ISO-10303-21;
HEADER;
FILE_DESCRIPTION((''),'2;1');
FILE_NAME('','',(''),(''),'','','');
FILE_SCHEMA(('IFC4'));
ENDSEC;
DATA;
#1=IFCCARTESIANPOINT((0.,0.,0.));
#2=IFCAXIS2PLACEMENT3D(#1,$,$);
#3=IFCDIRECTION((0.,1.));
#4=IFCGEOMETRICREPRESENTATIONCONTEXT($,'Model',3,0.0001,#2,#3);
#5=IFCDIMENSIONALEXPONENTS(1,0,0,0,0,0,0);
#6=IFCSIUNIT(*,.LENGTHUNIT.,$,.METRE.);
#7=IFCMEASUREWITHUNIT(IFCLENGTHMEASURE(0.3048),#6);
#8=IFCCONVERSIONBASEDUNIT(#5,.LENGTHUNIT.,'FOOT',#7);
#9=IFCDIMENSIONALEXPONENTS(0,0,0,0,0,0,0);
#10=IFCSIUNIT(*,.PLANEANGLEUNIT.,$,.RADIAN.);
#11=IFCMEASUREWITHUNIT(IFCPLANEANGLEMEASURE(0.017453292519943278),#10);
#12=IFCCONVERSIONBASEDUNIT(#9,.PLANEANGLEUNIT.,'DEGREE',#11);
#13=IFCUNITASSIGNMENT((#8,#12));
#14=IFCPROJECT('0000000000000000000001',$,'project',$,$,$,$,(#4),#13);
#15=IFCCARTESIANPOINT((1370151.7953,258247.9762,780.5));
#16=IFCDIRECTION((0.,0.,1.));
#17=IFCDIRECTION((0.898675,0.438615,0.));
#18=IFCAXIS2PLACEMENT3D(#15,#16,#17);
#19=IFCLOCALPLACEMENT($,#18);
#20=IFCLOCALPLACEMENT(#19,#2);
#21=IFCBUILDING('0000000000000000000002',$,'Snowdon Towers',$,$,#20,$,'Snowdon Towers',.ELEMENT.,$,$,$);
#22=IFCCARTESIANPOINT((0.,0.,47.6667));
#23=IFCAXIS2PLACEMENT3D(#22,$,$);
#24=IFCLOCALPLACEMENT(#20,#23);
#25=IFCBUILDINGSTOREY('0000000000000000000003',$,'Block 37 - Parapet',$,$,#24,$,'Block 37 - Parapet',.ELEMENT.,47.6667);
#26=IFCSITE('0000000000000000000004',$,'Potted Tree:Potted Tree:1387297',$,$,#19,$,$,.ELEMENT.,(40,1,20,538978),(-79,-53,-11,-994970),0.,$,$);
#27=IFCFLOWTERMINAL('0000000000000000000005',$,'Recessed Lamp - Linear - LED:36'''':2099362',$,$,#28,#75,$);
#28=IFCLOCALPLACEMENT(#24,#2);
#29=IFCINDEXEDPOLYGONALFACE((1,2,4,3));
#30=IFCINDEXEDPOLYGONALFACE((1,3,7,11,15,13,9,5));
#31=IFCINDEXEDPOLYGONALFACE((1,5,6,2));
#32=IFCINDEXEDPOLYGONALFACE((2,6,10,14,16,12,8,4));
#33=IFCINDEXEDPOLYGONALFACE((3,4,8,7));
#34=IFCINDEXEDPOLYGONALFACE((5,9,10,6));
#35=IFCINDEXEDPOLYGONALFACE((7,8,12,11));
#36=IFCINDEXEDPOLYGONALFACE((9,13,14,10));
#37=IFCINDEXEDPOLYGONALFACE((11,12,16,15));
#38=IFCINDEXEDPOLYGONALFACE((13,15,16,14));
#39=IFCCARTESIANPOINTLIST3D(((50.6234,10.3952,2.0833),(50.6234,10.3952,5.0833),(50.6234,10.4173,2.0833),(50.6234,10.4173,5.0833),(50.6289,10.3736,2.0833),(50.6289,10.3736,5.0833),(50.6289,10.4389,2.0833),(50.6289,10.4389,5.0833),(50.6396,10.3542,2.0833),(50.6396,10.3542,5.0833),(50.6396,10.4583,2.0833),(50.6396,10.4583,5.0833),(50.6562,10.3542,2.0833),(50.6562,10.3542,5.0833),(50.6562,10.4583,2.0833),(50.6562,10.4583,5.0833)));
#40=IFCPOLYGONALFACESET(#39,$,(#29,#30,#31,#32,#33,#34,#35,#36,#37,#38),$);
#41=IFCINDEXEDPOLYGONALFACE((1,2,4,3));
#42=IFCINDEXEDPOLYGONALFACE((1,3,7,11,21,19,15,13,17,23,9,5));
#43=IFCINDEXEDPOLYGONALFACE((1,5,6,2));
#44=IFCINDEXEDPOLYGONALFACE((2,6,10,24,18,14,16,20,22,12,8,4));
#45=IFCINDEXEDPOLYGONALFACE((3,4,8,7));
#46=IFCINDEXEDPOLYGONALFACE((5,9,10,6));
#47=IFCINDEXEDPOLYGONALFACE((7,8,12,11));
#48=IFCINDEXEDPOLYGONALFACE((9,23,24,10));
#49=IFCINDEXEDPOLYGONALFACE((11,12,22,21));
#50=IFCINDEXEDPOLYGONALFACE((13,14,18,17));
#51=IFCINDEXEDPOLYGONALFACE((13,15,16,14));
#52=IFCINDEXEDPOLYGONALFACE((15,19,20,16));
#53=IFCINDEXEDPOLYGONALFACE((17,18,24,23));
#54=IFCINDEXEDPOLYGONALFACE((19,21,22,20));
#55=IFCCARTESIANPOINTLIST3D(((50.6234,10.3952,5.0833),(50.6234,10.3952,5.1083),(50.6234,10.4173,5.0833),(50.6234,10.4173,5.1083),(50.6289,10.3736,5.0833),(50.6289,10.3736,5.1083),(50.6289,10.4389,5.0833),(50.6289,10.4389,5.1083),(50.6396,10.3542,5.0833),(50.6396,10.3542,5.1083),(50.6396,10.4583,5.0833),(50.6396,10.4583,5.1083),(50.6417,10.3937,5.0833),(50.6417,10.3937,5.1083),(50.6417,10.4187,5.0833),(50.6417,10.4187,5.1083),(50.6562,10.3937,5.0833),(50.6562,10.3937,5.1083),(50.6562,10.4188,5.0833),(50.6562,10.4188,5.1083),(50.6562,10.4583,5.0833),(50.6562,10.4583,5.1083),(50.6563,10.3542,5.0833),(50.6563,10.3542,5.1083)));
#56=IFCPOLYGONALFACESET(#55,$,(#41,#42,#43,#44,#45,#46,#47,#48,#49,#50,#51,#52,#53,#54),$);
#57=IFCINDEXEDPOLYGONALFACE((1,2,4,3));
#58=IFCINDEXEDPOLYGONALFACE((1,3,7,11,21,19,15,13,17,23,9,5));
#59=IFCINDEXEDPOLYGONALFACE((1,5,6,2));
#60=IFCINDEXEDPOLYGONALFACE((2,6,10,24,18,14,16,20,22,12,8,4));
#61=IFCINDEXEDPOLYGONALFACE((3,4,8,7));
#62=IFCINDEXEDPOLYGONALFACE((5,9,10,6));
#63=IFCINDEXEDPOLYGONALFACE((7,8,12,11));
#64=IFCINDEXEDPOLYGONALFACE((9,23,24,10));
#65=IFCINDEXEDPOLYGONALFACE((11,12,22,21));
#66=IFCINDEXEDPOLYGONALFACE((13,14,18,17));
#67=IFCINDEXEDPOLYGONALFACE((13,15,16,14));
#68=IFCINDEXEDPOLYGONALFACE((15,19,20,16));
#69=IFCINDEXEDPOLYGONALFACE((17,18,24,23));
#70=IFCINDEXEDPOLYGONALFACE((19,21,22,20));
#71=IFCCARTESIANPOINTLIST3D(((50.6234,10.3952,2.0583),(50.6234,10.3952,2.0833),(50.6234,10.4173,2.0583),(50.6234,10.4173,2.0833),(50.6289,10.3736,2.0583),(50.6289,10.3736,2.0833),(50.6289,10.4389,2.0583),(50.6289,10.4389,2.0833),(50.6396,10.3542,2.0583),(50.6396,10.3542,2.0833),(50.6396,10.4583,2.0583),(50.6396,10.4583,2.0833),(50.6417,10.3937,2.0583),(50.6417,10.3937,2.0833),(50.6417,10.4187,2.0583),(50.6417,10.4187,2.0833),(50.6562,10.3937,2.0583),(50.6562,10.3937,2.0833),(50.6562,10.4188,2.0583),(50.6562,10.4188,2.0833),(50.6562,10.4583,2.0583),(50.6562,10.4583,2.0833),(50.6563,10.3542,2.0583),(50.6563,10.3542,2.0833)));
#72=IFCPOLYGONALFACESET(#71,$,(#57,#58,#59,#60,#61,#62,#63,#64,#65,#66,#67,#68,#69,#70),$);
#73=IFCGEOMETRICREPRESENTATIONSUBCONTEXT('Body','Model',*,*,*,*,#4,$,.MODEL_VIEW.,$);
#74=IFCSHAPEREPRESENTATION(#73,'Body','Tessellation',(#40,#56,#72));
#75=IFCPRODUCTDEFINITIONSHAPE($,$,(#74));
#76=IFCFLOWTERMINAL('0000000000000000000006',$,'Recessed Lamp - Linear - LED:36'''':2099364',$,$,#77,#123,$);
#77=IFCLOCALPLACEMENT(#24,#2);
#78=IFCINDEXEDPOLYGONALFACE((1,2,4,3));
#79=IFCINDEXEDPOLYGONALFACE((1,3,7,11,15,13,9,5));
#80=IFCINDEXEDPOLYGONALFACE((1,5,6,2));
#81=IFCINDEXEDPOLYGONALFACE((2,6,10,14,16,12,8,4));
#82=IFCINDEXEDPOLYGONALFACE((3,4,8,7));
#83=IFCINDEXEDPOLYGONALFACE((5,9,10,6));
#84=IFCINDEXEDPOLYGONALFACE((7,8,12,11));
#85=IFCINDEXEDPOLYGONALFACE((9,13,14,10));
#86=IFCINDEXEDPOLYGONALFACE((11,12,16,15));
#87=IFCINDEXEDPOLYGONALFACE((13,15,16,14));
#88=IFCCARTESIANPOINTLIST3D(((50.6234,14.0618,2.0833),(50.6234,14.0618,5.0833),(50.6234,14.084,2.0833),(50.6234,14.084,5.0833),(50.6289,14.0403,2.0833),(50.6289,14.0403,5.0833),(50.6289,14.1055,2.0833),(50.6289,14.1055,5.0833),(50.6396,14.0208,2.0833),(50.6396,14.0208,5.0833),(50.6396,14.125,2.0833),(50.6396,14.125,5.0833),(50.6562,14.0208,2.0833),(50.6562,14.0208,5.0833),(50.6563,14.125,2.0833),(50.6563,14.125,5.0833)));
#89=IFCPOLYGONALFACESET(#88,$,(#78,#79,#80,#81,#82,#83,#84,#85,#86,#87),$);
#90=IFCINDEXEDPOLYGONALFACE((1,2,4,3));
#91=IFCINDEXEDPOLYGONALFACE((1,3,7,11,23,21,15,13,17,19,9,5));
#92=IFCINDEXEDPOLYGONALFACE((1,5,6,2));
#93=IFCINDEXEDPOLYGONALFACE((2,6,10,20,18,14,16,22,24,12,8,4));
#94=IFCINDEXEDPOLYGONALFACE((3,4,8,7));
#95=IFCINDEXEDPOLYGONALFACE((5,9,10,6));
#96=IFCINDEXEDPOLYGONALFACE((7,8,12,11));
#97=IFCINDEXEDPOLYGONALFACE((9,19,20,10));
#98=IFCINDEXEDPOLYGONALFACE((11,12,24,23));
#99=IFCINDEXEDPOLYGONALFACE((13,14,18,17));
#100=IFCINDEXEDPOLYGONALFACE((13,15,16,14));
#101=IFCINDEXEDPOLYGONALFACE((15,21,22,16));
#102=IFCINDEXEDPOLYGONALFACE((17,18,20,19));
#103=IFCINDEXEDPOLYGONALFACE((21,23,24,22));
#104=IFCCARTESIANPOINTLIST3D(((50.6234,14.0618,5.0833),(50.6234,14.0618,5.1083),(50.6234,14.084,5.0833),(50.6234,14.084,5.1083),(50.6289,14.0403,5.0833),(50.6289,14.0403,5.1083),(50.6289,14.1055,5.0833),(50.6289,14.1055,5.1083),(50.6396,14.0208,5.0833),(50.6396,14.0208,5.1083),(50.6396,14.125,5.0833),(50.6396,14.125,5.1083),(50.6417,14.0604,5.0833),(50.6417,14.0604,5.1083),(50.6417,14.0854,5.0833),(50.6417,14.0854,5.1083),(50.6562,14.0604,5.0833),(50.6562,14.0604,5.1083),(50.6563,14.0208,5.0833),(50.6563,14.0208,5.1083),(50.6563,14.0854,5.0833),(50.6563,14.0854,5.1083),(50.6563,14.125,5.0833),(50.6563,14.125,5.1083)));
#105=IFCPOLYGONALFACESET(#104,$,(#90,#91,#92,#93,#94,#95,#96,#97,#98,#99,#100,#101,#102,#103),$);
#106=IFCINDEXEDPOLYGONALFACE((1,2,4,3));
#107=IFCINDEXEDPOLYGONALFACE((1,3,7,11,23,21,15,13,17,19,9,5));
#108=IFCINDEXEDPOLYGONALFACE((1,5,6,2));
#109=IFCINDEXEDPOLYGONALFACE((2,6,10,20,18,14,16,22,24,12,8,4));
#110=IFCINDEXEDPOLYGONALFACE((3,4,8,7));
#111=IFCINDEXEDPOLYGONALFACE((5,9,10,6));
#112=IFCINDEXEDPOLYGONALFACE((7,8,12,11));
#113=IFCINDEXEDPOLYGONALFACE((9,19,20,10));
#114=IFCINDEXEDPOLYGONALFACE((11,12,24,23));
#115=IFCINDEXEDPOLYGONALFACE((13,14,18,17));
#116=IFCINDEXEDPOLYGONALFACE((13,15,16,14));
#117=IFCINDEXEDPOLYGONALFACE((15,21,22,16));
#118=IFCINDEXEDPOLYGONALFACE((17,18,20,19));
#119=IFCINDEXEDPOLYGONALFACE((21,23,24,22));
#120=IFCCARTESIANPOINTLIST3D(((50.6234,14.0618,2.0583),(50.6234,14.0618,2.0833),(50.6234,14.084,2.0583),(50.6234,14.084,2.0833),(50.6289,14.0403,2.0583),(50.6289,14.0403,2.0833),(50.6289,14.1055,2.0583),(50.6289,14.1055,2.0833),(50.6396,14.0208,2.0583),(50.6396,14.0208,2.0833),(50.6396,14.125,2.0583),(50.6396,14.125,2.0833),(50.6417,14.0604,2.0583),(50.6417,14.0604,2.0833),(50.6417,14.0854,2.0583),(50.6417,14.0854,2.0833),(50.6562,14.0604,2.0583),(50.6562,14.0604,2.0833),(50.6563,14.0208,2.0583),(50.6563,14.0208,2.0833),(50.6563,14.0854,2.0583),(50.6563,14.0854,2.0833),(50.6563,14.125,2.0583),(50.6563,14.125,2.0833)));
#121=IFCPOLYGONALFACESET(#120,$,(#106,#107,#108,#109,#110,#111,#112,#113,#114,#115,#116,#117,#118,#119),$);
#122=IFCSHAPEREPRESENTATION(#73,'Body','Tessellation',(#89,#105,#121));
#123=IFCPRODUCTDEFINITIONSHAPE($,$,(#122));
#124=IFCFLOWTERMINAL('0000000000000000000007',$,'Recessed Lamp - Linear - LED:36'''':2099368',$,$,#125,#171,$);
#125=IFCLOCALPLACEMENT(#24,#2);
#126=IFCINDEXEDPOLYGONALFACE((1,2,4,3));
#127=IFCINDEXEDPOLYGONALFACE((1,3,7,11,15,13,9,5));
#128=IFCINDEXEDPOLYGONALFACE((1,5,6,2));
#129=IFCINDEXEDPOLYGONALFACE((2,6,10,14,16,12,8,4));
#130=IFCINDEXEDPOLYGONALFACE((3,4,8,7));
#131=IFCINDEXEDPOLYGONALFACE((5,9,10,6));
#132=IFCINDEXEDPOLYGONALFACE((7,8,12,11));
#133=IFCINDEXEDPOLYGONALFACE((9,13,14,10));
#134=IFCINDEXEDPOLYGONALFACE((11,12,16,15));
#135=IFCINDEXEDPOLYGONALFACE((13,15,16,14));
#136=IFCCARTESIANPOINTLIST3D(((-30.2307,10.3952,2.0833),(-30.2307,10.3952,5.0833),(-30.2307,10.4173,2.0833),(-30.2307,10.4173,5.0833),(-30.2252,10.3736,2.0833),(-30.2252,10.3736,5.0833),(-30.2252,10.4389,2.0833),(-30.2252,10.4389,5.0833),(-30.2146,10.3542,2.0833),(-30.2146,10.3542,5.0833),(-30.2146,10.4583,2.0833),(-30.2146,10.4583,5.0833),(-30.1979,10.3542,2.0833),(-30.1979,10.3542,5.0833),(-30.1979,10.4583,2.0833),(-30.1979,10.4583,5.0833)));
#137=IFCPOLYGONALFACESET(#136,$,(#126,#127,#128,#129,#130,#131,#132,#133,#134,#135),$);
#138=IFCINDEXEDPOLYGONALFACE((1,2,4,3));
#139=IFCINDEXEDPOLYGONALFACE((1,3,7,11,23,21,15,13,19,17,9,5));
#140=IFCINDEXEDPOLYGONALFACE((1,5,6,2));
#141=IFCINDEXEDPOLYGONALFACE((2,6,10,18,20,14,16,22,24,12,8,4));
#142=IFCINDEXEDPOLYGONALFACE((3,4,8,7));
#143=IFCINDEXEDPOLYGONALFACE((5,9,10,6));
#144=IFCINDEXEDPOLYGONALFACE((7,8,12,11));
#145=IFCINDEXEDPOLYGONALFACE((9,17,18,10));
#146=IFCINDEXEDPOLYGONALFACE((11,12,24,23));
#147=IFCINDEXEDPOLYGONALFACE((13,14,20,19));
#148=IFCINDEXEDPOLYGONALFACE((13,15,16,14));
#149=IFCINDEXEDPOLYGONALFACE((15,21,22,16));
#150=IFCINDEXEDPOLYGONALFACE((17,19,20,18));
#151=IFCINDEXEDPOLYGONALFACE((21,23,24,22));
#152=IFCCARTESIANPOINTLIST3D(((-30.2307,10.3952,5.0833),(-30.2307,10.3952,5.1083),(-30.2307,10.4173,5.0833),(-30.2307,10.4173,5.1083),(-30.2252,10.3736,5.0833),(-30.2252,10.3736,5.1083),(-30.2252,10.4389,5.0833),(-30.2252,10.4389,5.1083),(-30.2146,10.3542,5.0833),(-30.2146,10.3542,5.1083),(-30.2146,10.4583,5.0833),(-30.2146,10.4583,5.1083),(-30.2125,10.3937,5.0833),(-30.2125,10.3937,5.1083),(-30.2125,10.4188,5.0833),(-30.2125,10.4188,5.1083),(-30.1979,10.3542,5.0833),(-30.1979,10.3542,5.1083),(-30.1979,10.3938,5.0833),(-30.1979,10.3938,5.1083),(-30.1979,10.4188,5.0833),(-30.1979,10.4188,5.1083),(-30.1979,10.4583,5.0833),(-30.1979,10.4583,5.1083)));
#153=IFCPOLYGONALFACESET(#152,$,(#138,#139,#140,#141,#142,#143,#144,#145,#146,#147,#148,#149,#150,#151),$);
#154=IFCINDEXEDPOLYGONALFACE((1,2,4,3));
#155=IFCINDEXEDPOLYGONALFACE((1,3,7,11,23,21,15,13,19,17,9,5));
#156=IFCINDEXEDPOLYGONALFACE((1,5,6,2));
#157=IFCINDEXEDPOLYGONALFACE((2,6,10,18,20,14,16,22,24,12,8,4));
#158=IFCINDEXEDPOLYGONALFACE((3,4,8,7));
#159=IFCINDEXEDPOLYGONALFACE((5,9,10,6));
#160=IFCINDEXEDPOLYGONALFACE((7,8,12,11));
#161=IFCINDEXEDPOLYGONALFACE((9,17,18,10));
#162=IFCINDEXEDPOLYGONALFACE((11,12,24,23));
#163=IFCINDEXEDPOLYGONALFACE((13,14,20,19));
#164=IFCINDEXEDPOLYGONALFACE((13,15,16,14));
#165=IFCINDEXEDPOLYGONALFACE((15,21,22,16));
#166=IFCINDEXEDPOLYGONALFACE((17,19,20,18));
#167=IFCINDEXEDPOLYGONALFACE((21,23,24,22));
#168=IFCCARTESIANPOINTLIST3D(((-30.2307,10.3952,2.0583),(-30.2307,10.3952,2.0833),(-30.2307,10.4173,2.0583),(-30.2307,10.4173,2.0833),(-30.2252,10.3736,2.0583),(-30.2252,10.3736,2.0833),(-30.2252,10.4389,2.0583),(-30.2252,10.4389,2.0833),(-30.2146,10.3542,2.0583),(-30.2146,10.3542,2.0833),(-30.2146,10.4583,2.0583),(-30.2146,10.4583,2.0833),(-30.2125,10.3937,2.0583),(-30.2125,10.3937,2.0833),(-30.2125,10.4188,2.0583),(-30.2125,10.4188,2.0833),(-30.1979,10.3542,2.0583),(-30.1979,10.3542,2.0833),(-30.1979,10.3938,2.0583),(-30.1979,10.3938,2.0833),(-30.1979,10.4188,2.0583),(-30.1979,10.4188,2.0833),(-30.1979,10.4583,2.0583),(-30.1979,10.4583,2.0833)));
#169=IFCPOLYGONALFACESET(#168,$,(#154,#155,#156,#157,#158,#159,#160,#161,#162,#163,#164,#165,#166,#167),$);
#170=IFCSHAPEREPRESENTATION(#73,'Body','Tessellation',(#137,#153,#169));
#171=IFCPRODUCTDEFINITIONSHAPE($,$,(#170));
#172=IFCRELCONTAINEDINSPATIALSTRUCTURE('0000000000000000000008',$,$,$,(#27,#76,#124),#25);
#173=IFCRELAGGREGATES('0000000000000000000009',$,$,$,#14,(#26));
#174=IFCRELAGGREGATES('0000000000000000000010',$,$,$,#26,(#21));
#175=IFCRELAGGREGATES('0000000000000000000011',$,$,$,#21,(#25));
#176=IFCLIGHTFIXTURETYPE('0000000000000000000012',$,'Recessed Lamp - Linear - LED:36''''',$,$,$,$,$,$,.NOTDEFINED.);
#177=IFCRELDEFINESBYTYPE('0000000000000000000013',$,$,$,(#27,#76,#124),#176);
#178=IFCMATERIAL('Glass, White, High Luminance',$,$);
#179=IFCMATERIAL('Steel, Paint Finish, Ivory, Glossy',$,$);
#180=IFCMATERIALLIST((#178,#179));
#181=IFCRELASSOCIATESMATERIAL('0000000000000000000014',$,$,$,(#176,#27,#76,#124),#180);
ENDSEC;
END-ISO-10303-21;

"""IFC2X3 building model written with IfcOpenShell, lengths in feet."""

from ifc_helpers import new_model, entity, si_unit, converted_unit, direction, frame, frame_2d, origin, place, context, subcontext, project, spatial, polyline, circle_curve, parameter, trimmed, segment, composite_curve, outline, extrude, source, transform, mapped, material, material_list, type_object, type_shapes, element, save


model = new_model("IFC2X3")

# Units and contexts
model_context = context("Model", 3, precision=0.0001, world=origin(), true_north=direction((0.0, 1.0)))
body_context = subcontext(model_context, "Body", "Model", "MODEL_VIEW")
ifc_project = project(units=[converted_unit("LENGTHUNIT", "FOOT", entity("IfcLengthMeasure", 0.3048), si_unit("LENGTHUNIT", "METRE"), dimensions=[1, 0, 0, 0, 0, 0, 0]), converted_unit("PLANEANGLEUNIT", "DEGREE", entity("IfcPlaneAngleMeasure", 0.017453292519943278), si_unit("PLANEANGLEUNIT", "RADIAN"), dimensions=[0, 0, 0, 0, 0, 0, 0])], contexts=[model_context])

# Site, building, storey
site_placement = place(None, frame((1370151.7953, 258247.9762, 780.5), z_axis=(0.0, 0.0, 1.0), x_axis=(0.898675, 0.438615, 0.0)))
site = spatial("IfcSite", under=ifc_project, at=site_placement, Name="Potted Tree:Potted Tree:1387297", CompositionType="ELEMENT", RefLatitude=(40, 1, 20, 538978), RefLongitude=(-79, -53, -11, -994970), RefElevation=0.0)
building_placement = place(site_placement, origin())
building = spatial("IfcBuilding", under=site, at=building_placement, Name="Snowdon Towers", LongName="Snowdon Towers", CompositionType="ELEMENT")
storey_placement = place(building_placement, frame((0.0, 0.0, 47.6667)))
storey = spatial("IfcBuildingStorey", under=building, at=storey_placement, Name="Block 37 - Parapet", LongName="Block 37 - Parapet", CompositionType="ELEMENT", Elevation=47.6667)

# Flow terminals
ifc_material_1 = material(Name="Glass, White, High Luminance")
ifc_material_2 = material(Name="Steel, Paint Finish, Ivory, Glossy")
ifc_material_list = material_list([ifc_material_1, ifc_material_2])
light_fixture_type = type_object("IfcLightFixtureType", Name="Recessed Lamp - Linear - LED:36''", PredefinedType="NOTDEFINED", material=ifc_material_list)
shared_shape = source(origin(), body_context, "Body", "SweptSolid", [
    extrude(outline(composite_curve([segment(trimmed(circle_curve(frame_2d((0.0, -0.0639), x_axis=(1.0, 0.0)), 0.089), [parameter(54.196986)], [parameter(125.803014)], True, "PARAMETER"), True, "CONTINUOUS"), segment(polyline([(-0.0521, 0.0083), (-0.0521, -0.0083)]), True, "CONTINUOUS"), segment(polyline([(-0.0521, -0.0083), (0.0521, -0.0083)]), True, "CONTINUOUS"), segment(polyline([(0.0521, -0.0083), (0.0521, 0.0083)]), True, "CONTINUOUS")], self_intersect=False)), frame((-1.5, 0.0, 0.0083), z_axis=(1.0, 0.0, 0.0), x_axis=(0.0, 1.0, 0.0)), (0.0, 0.0, 1.0), 3.0),
    extrude(outline(composite_curve([segment(trimmed(circle_curve(frame_2d((0.0, -0.0633), x_axis=(1.0, 0.0)), 0.089), [parameter(54.196986)], [parameter(125.803014)], True, "PARAMETER"), True, "CONTINUOUS"), segment(polyline([(-0.0521, 0.0089), (-0.0521, -0.0078)]), True, "CONTINUOUS"), segment(polyline([(-0.0521, -0.0078), (-0.0125, -0.0078)]), True, "CONTINUOUS"), segment(polyline([(-0.0125, -0.0078), (-0.0125, 0.0068)]), True, "CONTINUOUS"), segment(polyline([(-0.0125, 0.0068), (0.0125, 0.0068)]), True, "CONTINUOUS"), segment(polyline([(0.0125, 0.0068), (0.0125, -0.0078)]), True, "CONTINUOUS"), segment(polyline([(0.0125, -0.0078), (0.0521, -0.0078)]), True, "CONTINUOUS"), segment(polyline([(0.0521, -0.0078), (0.0521, 0.0089)]), True, "CONTINUOUS")], self_intersect=False)), frame((1.5, 0.0, 0.0078), z_axis=(1.0, 0.0, 0.0), x_axis=(0.0, 1.0, 0.0)), (0.0, 0.0, 1.0), 0.025),
    extrude(outline(composite_curve([segment(trimmed(circle_curve(frame_2d((0.0, -0.0633), x_axis=(1.0, 0.0)), 0.089), [parameter(54.196986)], [parameter(125.803014)], True, "PARAMETER"), True, "CONTINUOUS"), segment(polyline([(-0.0521, 0.0089), (-0.0521, -0.0078)]), True, "CONTINUOUS"), segment(polyline([(-0.0521, -0.0078), (-0.0125, -0.0078)]), True, "CONTINUOUS"), segment(polyline([(-0.0125, -0.0078), (-0.0125, 0.0068)]), True, "CONTINUOUS"), segment(polyline([(-0.0125, 0.0068), (0.0125, 0.0068)]), True, "CONTINUOUS"), segment(polyline([(0.0125, 0.0068), (0.0125, -0.0078)]), True, "CONTINUOUS"), segment(polyline([(0.0125, -0.0078), (0.0521, -0.0078)]), True, "CONTINUOUS"), segment(polyline([(0.0521, -0.0078), (0.0521, 0.0089)]), True, "CONTINUOUS")], self_intersect=False)), frame((-1.525, 0.0, 0.0078), z_axis=(1.0, 0.0, 0.0), x_axis=(0.0, 1.0, 0.0)), (0.0, 0.0, 1.0), 0.025),
])
type_shapes(light_fixture_type, [shared_shape])
for number, where, z_axis, x_axis, name in (
    (1, (50.6562, 10.4062, 3.5833), (-1.0, 0.0, 0.0), (0.0, 0.0, 1.0), "Recessed Lamp - Linear - LED:36'':2099362"),
    (2, (50.6562, 14.0729, 3.5833), (-1.0, 0.0, 0.0), (0.0, 0.0, 1.0), "Recessed Lamp - Linear - LED:36'':2099364"),
    (3, (-30.1979, 10.4062, 3.5833), (-1.0, 0.0, 0.0), (0.0, 0.0, 1.0), "Recessed Lamp - Linear - LED:36'':2099368"),
):
    element("IfcFlowTerminal", number, at=place(storey_placement, frame(where, z_axis=z_axis, x_axis=x_axis)), inside=storey, type_object=light_fixture_type, material=ifc_material_list, Name=name, context=body_context, shape_type="MappedRepresentation", body=[
        mapped(shared_shape, transform((0.0, 0.0, 0.0), scale=1.0)),
    ])

save(model, "model.ifc")
